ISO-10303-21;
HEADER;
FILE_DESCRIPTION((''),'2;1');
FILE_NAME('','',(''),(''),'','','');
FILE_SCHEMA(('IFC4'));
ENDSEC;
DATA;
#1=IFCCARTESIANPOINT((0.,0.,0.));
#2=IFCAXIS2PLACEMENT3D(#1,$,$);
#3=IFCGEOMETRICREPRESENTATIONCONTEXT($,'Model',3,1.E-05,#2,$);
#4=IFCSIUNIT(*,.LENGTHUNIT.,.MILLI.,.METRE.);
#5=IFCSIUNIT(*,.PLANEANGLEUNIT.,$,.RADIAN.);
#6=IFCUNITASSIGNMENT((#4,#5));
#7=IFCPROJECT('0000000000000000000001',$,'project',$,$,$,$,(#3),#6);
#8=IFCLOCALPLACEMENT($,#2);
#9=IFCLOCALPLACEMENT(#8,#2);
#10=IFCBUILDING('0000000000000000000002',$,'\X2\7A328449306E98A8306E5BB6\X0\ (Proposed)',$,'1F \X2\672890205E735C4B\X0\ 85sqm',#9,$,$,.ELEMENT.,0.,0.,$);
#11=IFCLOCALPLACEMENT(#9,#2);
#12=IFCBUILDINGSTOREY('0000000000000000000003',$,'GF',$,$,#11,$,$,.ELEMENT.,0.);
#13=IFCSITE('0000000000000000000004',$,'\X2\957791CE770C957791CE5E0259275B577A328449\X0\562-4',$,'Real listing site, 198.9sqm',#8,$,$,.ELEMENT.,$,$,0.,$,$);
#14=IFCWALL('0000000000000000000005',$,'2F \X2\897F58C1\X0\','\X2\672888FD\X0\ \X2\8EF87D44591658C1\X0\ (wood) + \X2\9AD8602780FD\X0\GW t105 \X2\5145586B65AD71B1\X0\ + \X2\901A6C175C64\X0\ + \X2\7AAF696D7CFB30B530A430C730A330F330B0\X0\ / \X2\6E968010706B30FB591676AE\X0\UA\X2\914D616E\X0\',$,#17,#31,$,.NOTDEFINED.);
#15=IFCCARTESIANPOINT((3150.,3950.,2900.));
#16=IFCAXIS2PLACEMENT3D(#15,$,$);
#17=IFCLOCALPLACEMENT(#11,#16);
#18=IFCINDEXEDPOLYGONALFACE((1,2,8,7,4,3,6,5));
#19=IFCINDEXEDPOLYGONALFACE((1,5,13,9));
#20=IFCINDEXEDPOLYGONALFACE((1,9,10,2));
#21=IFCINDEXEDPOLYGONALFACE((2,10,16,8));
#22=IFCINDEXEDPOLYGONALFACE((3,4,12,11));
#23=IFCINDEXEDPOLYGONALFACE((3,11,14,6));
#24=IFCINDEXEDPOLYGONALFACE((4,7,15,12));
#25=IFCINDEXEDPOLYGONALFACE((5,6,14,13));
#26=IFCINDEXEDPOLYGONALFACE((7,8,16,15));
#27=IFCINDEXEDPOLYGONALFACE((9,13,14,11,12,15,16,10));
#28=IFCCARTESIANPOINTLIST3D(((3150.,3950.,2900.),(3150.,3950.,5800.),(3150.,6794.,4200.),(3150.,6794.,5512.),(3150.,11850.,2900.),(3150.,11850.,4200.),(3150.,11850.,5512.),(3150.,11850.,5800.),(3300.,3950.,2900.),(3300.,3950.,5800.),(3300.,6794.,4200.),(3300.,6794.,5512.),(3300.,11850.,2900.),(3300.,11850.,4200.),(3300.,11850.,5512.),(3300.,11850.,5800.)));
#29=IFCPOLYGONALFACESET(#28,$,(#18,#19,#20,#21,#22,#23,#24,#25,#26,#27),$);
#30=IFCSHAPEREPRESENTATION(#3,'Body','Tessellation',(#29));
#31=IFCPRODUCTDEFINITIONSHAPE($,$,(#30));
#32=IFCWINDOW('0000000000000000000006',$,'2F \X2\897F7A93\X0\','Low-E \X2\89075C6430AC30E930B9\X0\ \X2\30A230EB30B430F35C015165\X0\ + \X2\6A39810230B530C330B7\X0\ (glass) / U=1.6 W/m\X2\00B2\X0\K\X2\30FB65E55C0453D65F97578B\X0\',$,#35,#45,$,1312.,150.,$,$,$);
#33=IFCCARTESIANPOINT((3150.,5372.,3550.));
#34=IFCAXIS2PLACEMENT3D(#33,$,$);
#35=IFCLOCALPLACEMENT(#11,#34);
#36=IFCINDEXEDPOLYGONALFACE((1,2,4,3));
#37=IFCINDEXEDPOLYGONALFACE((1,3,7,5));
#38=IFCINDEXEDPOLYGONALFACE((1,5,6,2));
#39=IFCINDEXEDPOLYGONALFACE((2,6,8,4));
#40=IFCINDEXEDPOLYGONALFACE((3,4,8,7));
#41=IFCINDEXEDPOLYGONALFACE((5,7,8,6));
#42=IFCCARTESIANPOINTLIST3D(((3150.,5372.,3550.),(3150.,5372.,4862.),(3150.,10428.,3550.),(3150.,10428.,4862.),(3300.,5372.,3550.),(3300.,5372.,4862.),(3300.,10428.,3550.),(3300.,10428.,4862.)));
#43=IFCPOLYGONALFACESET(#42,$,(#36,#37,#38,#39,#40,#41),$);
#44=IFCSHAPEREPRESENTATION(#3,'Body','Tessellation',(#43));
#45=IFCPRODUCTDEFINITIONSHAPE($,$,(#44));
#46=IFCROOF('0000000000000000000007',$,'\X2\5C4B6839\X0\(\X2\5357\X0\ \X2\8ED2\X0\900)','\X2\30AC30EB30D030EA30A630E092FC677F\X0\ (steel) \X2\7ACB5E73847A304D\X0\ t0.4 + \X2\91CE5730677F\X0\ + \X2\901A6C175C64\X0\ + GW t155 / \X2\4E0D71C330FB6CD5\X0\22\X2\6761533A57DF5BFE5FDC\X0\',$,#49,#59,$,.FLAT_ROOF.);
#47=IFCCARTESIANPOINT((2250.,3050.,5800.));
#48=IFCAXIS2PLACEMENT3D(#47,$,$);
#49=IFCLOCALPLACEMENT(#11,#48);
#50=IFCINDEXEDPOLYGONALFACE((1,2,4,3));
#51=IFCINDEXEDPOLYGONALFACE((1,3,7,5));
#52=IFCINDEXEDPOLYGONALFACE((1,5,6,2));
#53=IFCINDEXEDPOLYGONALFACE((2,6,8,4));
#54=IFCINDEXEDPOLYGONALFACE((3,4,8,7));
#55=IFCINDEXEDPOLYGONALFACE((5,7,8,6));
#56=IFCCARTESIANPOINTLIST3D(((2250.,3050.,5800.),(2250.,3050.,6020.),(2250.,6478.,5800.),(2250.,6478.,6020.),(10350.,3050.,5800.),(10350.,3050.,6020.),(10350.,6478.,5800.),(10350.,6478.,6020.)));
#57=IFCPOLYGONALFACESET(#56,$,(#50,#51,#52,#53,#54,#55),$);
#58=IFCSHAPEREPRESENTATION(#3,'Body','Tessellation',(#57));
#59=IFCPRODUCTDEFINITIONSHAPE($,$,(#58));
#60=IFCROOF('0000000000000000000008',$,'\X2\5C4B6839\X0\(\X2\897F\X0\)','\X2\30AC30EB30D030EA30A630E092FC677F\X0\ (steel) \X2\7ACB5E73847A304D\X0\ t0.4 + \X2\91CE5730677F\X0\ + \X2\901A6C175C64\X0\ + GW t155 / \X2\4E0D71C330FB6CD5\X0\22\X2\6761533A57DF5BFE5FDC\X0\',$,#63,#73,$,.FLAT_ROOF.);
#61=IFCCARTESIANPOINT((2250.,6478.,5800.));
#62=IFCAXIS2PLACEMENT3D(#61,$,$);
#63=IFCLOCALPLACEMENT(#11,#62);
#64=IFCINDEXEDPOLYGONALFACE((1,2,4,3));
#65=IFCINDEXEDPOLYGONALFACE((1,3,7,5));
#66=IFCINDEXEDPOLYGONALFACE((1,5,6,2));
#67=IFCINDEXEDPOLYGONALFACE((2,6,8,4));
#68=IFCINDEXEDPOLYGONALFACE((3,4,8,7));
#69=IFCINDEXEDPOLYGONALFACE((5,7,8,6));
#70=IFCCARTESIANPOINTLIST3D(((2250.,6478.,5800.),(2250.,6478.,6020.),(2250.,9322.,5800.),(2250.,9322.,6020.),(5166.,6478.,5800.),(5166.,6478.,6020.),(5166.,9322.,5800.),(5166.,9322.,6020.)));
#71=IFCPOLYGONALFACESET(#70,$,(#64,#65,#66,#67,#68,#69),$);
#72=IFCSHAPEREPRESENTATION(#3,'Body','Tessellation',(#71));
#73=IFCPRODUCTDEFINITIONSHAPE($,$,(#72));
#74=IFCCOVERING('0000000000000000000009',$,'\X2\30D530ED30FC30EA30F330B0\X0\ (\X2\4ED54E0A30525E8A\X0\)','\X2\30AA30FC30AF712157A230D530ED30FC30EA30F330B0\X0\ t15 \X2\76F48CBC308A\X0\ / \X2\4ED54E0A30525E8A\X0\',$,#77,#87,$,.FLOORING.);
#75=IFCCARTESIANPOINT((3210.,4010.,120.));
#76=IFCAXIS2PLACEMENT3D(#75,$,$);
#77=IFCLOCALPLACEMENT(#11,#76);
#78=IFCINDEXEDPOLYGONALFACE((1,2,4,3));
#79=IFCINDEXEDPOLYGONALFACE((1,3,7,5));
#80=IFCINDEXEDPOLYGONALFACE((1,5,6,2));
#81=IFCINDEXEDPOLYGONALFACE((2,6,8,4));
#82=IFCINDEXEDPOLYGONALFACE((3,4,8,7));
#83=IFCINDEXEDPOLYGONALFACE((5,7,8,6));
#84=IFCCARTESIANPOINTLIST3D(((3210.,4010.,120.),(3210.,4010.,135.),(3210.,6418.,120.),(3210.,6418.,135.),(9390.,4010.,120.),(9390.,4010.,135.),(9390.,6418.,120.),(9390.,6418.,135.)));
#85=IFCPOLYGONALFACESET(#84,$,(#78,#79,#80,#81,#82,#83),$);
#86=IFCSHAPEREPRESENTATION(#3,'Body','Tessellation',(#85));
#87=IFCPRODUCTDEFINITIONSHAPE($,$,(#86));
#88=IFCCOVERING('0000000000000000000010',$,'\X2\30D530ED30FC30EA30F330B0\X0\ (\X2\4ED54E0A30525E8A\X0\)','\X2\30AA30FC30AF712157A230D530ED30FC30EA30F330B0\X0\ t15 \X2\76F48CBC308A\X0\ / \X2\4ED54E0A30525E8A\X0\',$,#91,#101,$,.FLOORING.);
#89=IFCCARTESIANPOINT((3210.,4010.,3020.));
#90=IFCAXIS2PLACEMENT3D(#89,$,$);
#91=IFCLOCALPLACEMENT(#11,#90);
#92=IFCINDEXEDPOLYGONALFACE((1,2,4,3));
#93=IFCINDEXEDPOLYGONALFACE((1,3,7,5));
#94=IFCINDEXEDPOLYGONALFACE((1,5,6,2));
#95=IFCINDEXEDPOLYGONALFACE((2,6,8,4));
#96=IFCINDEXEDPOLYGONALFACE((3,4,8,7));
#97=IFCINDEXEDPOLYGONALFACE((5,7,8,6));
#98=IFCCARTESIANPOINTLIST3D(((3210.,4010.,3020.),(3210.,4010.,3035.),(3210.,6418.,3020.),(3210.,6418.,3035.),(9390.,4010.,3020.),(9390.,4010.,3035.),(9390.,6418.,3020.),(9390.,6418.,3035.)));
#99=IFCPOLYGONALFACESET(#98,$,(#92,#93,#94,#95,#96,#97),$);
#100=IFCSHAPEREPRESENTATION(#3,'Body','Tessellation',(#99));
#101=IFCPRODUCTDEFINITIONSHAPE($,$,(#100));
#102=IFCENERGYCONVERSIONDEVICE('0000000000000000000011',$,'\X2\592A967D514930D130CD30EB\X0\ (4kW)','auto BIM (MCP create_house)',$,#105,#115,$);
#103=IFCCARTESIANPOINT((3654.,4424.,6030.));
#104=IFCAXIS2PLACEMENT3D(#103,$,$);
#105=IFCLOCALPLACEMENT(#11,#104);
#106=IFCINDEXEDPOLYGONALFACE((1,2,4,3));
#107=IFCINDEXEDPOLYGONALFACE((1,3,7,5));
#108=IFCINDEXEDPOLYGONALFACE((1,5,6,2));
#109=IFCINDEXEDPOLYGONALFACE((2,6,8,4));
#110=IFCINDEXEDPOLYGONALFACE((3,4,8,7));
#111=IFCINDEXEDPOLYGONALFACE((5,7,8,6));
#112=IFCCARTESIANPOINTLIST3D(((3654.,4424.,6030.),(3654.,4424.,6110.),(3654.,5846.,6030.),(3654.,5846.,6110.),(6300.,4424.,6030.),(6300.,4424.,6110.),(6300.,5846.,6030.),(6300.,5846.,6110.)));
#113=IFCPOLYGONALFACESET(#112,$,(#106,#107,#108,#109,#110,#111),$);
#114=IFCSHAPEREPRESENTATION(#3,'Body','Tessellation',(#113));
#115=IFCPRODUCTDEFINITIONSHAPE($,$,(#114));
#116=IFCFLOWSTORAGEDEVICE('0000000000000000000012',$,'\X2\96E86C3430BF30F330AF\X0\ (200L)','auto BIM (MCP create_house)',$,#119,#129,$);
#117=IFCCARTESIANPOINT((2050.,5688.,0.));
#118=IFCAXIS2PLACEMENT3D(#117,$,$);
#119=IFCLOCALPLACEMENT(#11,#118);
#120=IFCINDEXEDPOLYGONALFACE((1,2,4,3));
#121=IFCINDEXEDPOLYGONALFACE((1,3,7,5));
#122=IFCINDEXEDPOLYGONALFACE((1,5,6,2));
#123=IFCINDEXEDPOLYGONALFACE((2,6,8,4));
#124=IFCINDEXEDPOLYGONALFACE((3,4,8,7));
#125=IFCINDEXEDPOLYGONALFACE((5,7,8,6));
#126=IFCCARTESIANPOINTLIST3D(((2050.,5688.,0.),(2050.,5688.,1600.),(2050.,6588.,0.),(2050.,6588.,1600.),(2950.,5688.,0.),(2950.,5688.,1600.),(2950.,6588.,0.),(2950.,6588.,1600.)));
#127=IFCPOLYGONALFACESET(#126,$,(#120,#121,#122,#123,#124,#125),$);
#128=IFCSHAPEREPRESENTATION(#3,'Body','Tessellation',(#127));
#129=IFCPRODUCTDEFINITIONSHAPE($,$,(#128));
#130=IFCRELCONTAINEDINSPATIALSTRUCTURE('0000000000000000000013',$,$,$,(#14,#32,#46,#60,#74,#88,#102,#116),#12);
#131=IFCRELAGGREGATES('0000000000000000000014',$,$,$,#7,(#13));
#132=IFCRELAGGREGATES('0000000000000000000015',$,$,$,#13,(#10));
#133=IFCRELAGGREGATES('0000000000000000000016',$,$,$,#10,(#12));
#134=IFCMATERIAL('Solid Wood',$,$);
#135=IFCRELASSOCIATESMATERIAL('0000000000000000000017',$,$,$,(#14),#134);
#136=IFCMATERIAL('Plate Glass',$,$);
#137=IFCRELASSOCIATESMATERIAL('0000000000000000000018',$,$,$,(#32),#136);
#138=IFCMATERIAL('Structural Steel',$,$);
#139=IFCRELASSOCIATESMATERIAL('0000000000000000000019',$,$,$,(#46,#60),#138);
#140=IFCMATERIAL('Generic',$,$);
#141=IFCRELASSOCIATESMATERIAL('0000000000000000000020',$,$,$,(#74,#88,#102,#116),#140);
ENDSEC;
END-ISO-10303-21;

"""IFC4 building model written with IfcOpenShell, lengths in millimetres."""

from ifc_helpers import new_model, si_unit, frame, frame_2d, origin, place, context, project, spatial, rectangle, extrude, material, element, fill, save


model = new_model("IFC4")

# Units and contexts
model_context = context("Model", 3, precision=1e-05, world=origin())
ifc_project = project(units=[si_unit("LENGTHUNIT", "METRE", prefix="MILLI"), si_unit("PLANEANGLEUNIT", "RADIAN")], contexts=[model_context])

# Site, building, storey
site_placement = place(None, origin())
site = spatial("IfcSite", under=ifc_project, at=site_placement, Name="長野県長野市大字稲葉562-4", ObjectType="Real listing site, 198.9sqm", CompositionType="ELEMENT", RefElevation=0.0)
building_placement = place(site_placement, origin())
building = spatial("IfcBuilding", under=site, at=building_placement, Name="稲葉の風の家 (Proposed)", ObjectType="1F 木造平屋 85sqm", CompositionType="ELEMENT", ElevationOfRefHeight=0.0, ElevationOfTerrain=0.0)
storey_placement = place(building_placement, origin())
storey = spatial("IfcBuildingStorey", under=building, at=storey_placement, Name="GF", CompositionType="ELEMENT", Elevation=0.0)

# Shared definitions
ifc_material_1 = material(Name="Solid Wood")
ifc_material_2 = material(Name="Generic")

# Shared definitions
ifc_material_3 = material(Name="Plate Glass")

# Wall, opening, window
wall_1_placement = place(storey_placement, frame((3150.0, 3950.0, 2900.0)))
wall_1 = element("IfcWall", 1, at=wall_1_placement, inside=storey, material=ifc_material_1, Name="2F 西壁", Description="木製 軸組外壁 (wood) + 高性能GW t105 充填断熱 + 通気層 + 窯業系サイディング / 準耐火・外皮UA配慮", PredefinedType="NOTDEFINED", context=model_context, shape_type="SweptSolid", body=[
    extrude(rectangle(XDim=150.0, YDim=7900.0, at=frame_2d((75.0, 3950.0))), frame((3150.0, 3950.0, 2900.0)), (0.0, 0.0, 1.0), 2900.0),
])
opening_1_placement = place(storey_placement, frame((3150.0, 5372.0, 3550.0)))
opening_1 = element("IfcOpeningElement", 2, at=opening_1_placement, cuts=wall_1, PredefinedType="NOTDEFINED", context=model_context, shape_type="SweptSolid", body=[
    extrude(rectangle(XDim=150.0, YDim=5056.0, at=frame_2d((75.0, 2528.0))), frame((3150.0, 5372.0, 3550.0)), (0.0, 0.0, 1.0), 1312.0),
])
window_1_placement = place(storey_placement, frame((3150.0, 5372.0, 3550.0)))
window_1 = element("IfcWindow", 3, at=window_1_placement, inside=storey, material=ifc_material_3, Name="2F 西窓", Description="Low-E 複層ガラス アルゴン封入 + 樹脂サッシ (glass) / U=1.6 W/m²K・日射取得型", OverallHeight=1312.0, OverallWidth=150.0, context=model_context, shape_type="SweptSolid", body=[
    extrude(rectangle(XDim=150.0, YDim=5056.0, at=frame_2d((75.0, 2528.0))), frame((3150.0, 5372.0, 3550.0)), (0.0, 0.0, 1.0), 1312.0),
])
fill(opening_1, window_1)

# Roofs
ifc_material_4 = material(Name="Structural Steel")
roof_1_placement = place(storey_placement, frame((2250.0, 3050.0, 5800.0)))
element("IfcRoof", 4, at=roof_1_placement, inside=storey, material=ifc_material_4, Name="屋根(南 軒900)", Description="ガルバリウム鋼板 (steel) 立平葺き t0.4 + 野地板 + 通気層 + GW t155 / 不燃・法22条区域対応", PredefinedType="FLAT_ROOF", context=model_context, shape_type="SweptSolid", body=[
    extrude(rectangle(XDim=8100.0, YDim=3428.0, at=frame_2d((4050.0, 1714.0))), frame((2250.0, 3050.0, 5800.0)), (0.0, 0.0, 1.0), 220.0),
])
roof_2_placement = place(storey_placement, frame((2250.0, 6478.0, 5800.0)))
element("IfcRoof", 5, at=roof_2_placement, inside=storey, material=ifc_material_4, Name="屋根(西)", Description="ガルバリウム鋼板 (steel) 立平葺き t0.4 + 野地板 + 通気層 + GW t155 / 不燃・法22条区域対応", PredefinedType="FLAT_ROOF", context=model_context, shape_type="SweptSolid", body=[
    extrude(rectangle(XDim=2916.0, YDim=2844.0, at=frame_2d((1458.0, 1422.0))), frame((2250.0, 6478.0, 5800.0)), (0.0, 0.0, 1.0), 220.0),
])

# Coverings
covering_1_placement = place(storey_placement, frame((3210.0, 4010.0, 120.0)))
element("IfcCovering", 6, at=covering_1_placement, inside=storey, material=ifc_material_2, Name="フローリング (仕上げ床)", Description="オーク無垢フローリング t15 直貼り / 仕上げ床", PredefinedType="FLOORING", context=model_context, shape_type="SweptSolid", body=[
    extrude(rectangle(XDim=6180.0, YDim=2408.0, at=frame_2d((3090.0, 1204.0))), frame((3210.0, 4010.0, 120.0)), (0.0, 0.0, 1.0), 15.0),
])
covering_2_placement = place(storey_placement, frame((3210.0, 4010.0, 3020.0)))
element("IfcCovering", 7, at=covering_2_placement, inside=storey, material=ifc_material_2, Name="フローリング (仕上げ床)", Description="オーク無垢フローリング t15 直貼り / 仕上げ床", PredefinedType="FLOORING", context=model_context, shape_type="SweptSolid", body=[
    extrude(rectangle(XDim=6180.0, YDim=2408.0, at=frame_2d((3090.0, 1204.0))), frame((3210.0, 4010.0, 3020.0)), (0.0, 0.0, 1.0), 15.0),
])

# Energy conversion device
energy_conversion_device_placement = place(storey_placement, frame((3654.0, 4424.0, 6030.0)))
element("IfcEnergyConversionDevice", 8, at=energy_conversion_device_placement, inside=storey, material=ifc_material_2, Name="太陽光パネル (4kW)", Description="auto BIM (MCP create_house)", context=model_context, shape_type="SweptSolid", body=[
    extrude(rectangle(XDim=2646.0, YDim=1422.0, at=frame_2d((1323.0, 711.0))), frame((3654.0, 4424.0, 6030.0)), (0.0, 0.0, 1.0), 80.0),
])

# Flow storage device
flow_storage_device_placement = place(storey_placement, frame((2050.0, 5688.0, 0.0)))
element("IfcFlowStorageDevice", 9, at=flow_storage_device_placement, inside=storey, material=ifc_material_2, Name="雨水タンク (200L)", Description="auto BIM (MCP create_house)", context=model_context, shape_type="SweptSolid", body=[
    extrude(rectangle(XDim=900.0, YDim=900.0, at=frame_2d((450.0, 450.0))), frame((2050.0, 5688.0, 0.0)), (0.0, 0.0, 1.0), 1600.0),
])

save(model, "model.ifc")
